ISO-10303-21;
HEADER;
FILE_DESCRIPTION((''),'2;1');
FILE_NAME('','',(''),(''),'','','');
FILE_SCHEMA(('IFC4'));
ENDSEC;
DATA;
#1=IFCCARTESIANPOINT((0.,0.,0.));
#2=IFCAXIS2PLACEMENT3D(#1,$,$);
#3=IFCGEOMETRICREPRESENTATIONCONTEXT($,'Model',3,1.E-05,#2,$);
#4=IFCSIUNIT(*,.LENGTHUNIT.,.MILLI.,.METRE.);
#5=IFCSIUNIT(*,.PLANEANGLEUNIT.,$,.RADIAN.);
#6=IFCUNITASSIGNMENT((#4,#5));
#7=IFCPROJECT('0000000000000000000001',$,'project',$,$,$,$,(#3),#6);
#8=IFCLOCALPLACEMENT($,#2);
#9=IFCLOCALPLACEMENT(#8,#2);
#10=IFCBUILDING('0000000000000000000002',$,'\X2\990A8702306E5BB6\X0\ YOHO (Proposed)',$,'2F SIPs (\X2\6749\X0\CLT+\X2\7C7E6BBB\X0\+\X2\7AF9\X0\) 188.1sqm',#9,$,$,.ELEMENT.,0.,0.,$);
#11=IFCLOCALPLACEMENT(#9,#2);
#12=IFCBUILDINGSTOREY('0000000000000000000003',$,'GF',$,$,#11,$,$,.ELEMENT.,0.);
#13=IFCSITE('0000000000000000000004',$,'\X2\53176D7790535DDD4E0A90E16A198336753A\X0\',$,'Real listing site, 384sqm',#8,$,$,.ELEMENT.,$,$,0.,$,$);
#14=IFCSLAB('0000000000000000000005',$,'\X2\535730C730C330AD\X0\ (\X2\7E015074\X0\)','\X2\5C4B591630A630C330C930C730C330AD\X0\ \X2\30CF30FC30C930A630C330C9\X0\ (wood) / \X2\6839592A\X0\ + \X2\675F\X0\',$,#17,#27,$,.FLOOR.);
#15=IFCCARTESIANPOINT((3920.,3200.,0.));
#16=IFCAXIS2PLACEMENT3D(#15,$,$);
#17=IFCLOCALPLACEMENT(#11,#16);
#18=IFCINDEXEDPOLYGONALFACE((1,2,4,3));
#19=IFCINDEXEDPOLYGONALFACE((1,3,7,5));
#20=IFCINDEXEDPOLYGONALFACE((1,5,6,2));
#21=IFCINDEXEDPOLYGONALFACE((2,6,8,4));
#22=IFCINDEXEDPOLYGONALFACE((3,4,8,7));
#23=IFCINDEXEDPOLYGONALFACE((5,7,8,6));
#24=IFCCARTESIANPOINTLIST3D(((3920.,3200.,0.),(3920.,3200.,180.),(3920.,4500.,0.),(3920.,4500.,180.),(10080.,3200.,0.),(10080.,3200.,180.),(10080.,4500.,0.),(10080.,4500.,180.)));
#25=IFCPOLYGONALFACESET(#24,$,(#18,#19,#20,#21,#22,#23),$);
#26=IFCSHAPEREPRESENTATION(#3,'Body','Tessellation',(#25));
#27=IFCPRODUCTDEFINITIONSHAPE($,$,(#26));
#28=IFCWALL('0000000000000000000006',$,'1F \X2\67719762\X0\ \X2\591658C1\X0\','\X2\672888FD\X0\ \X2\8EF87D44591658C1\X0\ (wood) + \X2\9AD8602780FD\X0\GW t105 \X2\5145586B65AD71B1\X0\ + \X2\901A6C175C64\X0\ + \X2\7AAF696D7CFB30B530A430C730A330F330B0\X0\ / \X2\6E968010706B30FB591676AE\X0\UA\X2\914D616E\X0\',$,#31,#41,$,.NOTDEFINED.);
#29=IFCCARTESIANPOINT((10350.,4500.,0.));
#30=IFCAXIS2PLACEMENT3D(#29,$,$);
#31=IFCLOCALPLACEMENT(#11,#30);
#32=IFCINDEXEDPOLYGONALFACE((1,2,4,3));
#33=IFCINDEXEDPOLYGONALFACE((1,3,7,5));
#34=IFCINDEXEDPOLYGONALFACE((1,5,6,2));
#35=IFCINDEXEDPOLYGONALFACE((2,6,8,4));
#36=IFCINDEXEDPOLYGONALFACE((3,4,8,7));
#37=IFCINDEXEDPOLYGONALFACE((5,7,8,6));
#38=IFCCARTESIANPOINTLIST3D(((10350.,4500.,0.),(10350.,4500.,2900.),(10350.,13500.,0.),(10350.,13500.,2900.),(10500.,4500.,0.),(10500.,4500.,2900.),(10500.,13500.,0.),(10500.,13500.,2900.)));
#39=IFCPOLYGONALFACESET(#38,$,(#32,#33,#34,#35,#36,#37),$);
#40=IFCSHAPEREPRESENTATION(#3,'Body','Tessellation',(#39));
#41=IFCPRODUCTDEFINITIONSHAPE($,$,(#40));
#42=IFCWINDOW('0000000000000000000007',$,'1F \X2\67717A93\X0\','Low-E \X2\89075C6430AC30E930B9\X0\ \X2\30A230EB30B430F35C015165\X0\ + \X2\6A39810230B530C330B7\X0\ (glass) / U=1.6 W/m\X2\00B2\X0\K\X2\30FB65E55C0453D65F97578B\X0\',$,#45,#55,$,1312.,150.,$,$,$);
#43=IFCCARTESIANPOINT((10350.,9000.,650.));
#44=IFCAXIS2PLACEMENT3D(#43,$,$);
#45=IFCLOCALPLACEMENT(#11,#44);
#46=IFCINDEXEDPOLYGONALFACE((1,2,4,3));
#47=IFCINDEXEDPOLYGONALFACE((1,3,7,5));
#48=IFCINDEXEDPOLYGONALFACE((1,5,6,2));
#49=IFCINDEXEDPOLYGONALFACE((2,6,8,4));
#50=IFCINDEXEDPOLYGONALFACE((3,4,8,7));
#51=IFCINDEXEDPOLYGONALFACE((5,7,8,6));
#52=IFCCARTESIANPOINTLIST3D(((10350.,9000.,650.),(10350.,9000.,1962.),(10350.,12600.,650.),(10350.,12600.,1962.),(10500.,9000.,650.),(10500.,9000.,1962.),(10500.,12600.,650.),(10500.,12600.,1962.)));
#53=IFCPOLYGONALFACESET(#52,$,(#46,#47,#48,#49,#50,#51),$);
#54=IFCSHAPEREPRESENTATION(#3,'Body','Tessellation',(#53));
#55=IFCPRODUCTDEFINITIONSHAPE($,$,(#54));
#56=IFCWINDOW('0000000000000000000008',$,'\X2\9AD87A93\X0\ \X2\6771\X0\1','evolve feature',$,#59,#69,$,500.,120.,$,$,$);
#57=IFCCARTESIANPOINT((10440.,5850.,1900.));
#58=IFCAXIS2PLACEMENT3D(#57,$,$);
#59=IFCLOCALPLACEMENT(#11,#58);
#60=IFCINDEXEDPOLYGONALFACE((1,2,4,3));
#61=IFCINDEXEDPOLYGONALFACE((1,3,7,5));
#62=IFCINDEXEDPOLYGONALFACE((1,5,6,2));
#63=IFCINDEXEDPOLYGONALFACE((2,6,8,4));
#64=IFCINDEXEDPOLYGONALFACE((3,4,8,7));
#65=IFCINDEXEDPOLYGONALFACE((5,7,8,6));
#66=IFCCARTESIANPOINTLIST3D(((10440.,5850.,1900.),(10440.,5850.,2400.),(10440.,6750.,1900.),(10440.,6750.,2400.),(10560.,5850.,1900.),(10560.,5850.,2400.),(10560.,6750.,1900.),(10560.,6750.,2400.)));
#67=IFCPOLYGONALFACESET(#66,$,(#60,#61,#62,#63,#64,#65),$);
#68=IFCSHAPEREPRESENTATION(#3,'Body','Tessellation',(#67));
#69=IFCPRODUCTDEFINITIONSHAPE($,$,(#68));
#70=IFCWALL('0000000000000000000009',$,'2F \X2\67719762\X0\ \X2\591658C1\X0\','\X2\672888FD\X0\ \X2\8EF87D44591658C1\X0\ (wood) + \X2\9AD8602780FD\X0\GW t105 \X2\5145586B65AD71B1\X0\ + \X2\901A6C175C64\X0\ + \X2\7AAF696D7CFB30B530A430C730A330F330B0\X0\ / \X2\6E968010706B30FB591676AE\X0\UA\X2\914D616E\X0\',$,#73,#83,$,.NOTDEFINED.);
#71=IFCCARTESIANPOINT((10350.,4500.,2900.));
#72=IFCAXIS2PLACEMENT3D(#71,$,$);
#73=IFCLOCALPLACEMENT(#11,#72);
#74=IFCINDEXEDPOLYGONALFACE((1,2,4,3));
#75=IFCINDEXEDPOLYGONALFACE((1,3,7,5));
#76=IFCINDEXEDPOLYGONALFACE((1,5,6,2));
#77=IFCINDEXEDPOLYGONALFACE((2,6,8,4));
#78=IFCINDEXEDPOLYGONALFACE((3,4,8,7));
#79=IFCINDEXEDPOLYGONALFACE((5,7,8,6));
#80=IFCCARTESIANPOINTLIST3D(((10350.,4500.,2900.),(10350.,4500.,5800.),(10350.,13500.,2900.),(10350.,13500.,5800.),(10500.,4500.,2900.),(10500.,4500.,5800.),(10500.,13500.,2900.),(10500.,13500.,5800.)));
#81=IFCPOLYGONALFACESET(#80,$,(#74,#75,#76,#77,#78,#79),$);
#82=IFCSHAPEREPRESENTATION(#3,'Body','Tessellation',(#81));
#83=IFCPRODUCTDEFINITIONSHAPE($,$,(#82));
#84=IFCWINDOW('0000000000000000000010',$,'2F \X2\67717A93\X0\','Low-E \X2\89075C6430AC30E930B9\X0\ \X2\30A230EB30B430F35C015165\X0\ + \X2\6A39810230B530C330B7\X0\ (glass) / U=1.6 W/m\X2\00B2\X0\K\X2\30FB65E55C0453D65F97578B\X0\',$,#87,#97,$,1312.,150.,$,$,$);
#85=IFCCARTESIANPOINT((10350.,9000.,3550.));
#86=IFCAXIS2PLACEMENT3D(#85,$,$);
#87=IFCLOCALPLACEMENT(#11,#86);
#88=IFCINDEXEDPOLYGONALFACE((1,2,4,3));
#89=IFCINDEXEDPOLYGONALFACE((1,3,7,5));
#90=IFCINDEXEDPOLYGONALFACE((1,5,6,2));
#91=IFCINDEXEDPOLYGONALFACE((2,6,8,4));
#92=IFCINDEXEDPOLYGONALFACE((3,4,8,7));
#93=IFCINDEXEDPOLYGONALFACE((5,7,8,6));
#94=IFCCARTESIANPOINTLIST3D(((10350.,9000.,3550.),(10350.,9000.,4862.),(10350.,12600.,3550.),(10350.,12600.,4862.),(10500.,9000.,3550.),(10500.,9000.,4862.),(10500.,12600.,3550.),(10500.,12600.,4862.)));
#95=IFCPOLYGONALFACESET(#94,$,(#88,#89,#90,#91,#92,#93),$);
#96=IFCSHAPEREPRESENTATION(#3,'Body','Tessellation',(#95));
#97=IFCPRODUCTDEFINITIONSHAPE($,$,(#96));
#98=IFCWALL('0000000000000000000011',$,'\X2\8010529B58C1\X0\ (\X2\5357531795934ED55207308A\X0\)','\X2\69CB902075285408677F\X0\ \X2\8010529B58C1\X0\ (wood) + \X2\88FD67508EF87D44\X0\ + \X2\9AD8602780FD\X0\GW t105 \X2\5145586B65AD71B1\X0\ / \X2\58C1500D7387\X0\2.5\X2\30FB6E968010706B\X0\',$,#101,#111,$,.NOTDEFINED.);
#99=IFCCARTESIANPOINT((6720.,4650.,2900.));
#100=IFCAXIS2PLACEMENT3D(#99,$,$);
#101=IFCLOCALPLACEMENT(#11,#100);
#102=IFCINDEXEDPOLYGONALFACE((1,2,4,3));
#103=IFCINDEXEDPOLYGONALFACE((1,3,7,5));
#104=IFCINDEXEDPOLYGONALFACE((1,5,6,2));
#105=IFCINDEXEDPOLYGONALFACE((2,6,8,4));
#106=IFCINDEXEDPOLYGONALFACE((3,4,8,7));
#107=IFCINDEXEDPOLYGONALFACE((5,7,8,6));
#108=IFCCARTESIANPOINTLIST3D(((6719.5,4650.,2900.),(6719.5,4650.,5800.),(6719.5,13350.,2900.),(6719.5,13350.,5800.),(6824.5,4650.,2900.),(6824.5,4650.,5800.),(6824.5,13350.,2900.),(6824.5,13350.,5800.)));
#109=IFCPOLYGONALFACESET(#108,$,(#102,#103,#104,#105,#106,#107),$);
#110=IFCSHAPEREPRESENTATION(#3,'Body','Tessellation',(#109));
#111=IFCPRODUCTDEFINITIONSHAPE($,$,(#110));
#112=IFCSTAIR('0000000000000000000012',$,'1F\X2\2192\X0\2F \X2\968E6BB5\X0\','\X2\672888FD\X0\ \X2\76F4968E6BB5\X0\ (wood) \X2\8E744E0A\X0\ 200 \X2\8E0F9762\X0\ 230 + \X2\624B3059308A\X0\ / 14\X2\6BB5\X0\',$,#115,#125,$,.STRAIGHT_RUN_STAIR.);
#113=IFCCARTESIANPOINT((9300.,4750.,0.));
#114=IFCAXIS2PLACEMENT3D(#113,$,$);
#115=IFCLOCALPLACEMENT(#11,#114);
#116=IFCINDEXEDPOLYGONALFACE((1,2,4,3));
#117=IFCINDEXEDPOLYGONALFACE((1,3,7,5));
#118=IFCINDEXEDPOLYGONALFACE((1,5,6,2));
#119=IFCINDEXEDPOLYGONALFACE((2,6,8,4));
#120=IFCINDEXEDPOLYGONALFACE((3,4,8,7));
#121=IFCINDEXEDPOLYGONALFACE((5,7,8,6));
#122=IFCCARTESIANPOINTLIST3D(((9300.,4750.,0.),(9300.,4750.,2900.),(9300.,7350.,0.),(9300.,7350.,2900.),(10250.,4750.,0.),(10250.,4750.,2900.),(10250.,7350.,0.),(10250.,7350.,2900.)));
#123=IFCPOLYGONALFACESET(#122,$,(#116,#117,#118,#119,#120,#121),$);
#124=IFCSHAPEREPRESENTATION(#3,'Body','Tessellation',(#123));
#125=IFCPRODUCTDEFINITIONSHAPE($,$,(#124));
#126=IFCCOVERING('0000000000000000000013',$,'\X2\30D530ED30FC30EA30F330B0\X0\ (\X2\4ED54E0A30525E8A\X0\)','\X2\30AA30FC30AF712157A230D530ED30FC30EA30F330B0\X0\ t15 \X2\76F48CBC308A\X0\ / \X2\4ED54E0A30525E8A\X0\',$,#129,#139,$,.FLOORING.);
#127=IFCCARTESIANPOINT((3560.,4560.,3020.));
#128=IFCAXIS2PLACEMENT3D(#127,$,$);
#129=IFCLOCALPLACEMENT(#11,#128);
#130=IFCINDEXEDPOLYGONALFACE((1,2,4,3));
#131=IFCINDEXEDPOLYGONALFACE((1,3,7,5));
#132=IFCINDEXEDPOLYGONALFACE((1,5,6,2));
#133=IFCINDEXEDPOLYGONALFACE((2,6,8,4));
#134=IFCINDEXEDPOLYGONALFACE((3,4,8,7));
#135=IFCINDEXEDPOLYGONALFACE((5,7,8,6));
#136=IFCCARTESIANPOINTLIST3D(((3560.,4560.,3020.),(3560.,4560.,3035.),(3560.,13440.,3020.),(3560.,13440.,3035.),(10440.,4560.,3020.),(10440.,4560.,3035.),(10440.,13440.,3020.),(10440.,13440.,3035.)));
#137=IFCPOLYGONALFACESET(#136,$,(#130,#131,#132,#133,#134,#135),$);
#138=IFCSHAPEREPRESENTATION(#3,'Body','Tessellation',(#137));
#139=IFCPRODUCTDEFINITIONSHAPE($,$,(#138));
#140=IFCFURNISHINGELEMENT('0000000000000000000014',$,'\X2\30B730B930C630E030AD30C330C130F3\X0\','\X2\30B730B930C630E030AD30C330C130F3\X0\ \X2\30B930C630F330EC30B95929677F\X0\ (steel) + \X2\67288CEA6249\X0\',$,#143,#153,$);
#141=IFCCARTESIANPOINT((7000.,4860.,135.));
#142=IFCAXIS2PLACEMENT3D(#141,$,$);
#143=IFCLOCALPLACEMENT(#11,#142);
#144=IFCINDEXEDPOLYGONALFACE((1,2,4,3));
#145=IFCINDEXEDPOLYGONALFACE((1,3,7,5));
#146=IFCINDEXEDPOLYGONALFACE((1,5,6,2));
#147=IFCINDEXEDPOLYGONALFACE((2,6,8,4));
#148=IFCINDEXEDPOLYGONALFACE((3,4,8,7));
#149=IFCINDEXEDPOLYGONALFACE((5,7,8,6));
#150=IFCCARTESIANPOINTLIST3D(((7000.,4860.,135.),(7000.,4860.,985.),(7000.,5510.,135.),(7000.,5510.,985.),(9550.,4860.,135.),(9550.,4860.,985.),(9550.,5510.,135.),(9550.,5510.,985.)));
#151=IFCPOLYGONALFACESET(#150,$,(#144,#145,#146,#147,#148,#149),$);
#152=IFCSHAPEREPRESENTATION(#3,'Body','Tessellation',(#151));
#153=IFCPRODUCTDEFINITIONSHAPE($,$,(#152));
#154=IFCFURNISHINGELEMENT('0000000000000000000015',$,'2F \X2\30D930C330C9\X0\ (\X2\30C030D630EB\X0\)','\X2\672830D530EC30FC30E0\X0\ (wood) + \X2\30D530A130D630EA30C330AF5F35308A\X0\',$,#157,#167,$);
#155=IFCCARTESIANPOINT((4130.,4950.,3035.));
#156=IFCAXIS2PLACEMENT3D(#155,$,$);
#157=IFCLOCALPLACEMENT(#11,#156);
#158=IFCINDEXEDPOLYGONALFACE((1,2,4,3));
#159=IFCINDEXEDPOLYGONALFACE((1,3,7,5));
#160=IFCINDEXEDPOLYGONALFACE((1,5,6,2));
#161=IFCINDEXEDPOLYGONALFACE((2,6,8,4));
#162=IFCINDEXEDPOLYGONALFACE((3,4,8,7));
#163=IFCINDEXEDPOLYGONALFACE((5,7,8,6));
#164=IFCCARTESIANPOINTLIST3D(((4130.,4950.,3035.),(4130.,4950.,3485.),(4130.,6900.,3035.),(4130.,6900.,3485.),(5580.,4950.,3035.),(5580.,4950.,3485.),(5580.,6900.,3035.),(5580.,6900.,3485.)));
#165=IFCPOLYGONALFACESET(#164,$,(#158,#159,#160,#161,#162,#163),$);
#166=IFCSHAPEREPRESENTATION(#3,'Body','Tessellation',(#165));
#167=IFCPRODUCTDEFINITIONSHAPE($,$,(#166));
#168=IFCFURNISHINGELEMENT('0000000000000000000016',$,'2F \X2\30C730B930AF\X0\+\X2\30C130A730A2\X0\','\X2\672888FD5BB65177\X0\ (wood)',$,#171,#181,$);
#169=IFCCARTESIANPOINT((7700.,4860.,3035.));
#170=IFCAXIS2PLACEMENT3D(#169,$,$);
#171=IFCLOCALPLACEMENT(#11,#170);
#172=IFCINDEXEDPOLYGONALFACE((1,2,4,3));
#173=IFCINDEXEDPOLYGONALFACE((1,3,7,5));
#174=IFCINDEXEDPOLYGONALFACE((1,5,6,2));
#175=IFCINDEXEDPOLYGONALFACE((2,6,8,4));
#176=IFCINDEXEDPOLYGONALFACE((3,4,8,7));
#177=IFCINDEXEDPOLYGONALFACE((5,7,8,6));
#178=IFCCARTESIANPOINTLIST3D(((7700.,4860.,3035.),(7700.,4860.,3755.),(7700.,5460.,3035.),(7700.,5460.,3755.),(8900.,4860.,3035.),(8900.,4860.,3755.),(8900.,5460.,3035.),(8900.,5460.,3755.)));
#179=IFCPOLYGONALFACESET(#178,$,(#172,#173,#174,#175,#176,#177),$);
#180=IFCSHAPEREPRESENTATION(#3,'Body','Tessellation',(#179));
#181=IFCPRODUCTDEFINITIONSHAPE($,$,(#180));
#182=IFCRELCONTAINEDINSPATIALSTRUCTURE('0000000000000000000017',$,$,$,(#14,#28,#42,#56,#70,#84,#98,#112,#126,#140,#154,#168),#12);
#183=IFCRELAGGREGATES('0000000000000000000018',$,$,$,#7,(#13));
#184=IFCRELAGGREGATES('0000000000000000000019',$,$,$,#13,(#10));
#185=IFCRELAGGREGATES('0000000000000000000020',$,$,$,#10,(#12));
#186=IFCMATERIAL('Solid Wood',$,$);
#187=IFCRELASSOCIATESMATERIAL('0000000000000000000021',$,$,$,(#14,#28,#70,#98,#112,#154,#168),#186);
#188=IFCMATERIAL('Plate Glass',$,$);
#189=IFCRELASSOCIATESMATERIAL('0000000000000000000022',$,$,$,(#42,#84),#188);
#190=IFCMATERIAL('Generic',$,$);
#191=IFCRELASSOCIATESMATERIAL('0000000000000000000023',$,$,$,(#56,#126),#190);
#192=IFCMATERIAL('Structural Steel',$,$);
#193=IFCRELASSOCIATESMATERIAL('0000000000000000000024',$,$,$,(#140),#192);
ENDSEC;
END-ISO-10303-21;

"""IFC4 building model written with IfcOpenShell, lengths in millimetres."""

from ifc_helpers import new_model, si_unit, frame, frame_2d, origin, place, context, project, spatial, rectangle, extrude, material, element, fill, save


model = new_model("IFC4")

# Units and contexts
model_context = context("Model", 3, precision=1e-05, world=origin())
ifc_project = project(units=[si_unit("LENGTHUNIT", "METRE", prefix="MILLI"), si_unit("PLANEANGLEUNIT", "RADIAN")], contexts=[model_context])

# Site, building, storey
site_placement = place(None, origin())
site = spatial("IfcSite", under=ifc_project, at=site_placement, Name="北海道川上郡標茶町", ObjectType="Real listing site, 384sqm", CompositionType="ELEMENT", RefElevation=0.0)
building_placement = place(site_placement, origin())
building = spatial("IfcBuilding", under=site, at=building_placement, Name="養蜂の家 YOHO (Proposed)", ObjectType="2F SIPs (杉CLT+籾殻+竹) 188.1sqm", CompositionType="ELEMENT", ElevationOfRefHeight=0.0, ElevationOfTerrain=0.0)
storey_placement = place(building_placement, origin())
storey = spatial("IfcBuildingStorey", under=building, at=storey_placement, Name="GF", CompositionType="ELEMENT", Elevation=0.0)

# Slab
ifc_material_1 = material(Name="Solid Wood")
slab_placement = place(storey_placement, frame((3920.0, 3200.0, 0.0)))
element("IfcSlab", 1, at=slab_placement, inside=storey, material=ifc_material_1, Name="南デッキ (縁側)", Description="屋外ウッドデッキ ハードウッド (wood) / 根太 + 束", PredefinedType="FLOOR", context=model_context, shape_type="SweptSolid", body=[
    extrude(rectangle(XDim=6160.0, YDim=1300.0, at=frame_2d((3080.0, 650.0))), frame((3920.0, 3200.0, 0.0)), (0.0, 0.0, 1.0), 180.0),
])

# Wall, openings, windows
wall_1_placement = place(storey_placement, frame((10350.0, 4500.0, 0.0)))
wall_1 = element("IfcWall", 2, at=wall_1_placement, inside=storey, material=ifc_material_1, Name="1F 東面 外壁", Description="木製 軸組外壁 (wood) + 高性能GW t105 充填断熱 + 通気層 + 窯業系サイディング / 準耐火・外皮UA配慮", PredefinedType="NOTDEFINED", context=model_context, shape_type="SweptSolid", body=[
    extrude(rectangle(XDim=150.0, YDim=9000.0, at=frame_2d((75.0, 4500.0))), frame((10350.0, 4500.0, 0.0)), (0.0, 0.0, 1.0), 2900.0),
])
opening_1_placement = place(storey_placement, frame((10350.0, 9000.0, 650.0)))
opening_1 = element("IfcOpeningElement", 3, at=opening_1_placement, cuts=wall_1, PredefinedType="NOTDEFINED", context=model_context, shape_type="SweptSolid", body=[
    extrude(rectangle(XDim=150.0, YDim=3600.0, at=frame_2d((75.0, 1800.0))), frame((10350.0, 9000.0, 650.0)), (0.0, 0.0, 1.0), 1312.0),
])
opening_2_placement = place(storey_placement, frame((10440.0, 5850.0, 1900.0)))
opening_2 = element("IfcOpeningElement", 4, at=opening_2_placement, cuts=wall_1, PredefinedType="NOTDEFINED", context=model_context, shape_type="SweptSolid", body=[
    extrude(rectangle(XDim=120.0, YDim=900.0, at=frame_2d((60.0, 450.0))), frame((10440.0, 5850.0, 1900.0)), (0.0, 0.0, 1.0), 500.0),
])
ifc_material_2 = material(Name="Plate Glass")
window_1_placement = place(storey_placement, frame((10350.0, 9000.0, 650.0)))
window_1 = element("IfcWindow", 5, at=window_1_placement, inside=storey, material=ifc_material_2, Name="1F 東窓", Description="Low-E 複層ガラス アルゴン封入 + 樹脂サッシ (glass) / U=1.6 W/m²K・日射取得型", OverallHeight=1312.0, OverallWidth=150.0, context=model_context, shape_type="SweptSolid", body=[
    extrude(rectangle(XDim=150.0, YDim=3600.0, at=frame_2d((75.0, 1800.0))), frame((10350.0, 9000.0, 650.0)), (0.0, 0.0, 1.0), 1312.0),
])
fill(opening_1, window_1)
ifc_material_3 = material(Name="Generic")
window_2_placement = place(storey_placement, frame((10440.0, 5850.0, 1900.0)))
window_2 = element("IfcWindow", 6, at=window_2_placement, inside=storey, material=ifc_material_3, Name="高窓 東1", Description="evolve feature", OverallHeight=500.0, OverallWidth=120.0, context=model_context, shape_type="SweptSolid", body=[
    extrude(rectangle(XDim=120.0, YDim=900.0, at=frame_2d((60.0, 450.0))), frame((10440.0, 5850.0, 1900.0)), (0.0, 0.0, 1.0), 500.0),
])
fill(opening_2, window_2)

# Wall, opening, window
wall_2_placement = place(storey_placement, frame((10350.0, 4500.0, 2900.0)))
wall_2 = element("IfcWall", 7, at=wall_2_placement, inside=storey, material=ifc_material_1, Name="2F 東面 外壁", Description="木製 軸組外壁 (wood) + 高性能GW t105 充填断熱 + 通気層 + 窯業系サイディング / 準耐火・外皮UA配慮", PredefinedType="NOTDEFINED", context=model_context, shape_type="SweptSolid", body=[
    extrude(rectangle(XDim=150.0, YDim=9000.0, at=frame_2d((75.0, 4500.0))), frame((10350.0, 4500.0, 2900.0)), (0.0, 0.0, 1.0), 2900.0),
])
opening_3_placement = place(storey_placement, frame((10350.0, 9000.0, 3550.0)))
opening_3 = element("IfcOpeningElement", 8, at=opening_3_placement, cuts=wall_2, PredefinedType="NOTDEFINED", context=model_context, shape_type="SweptSolid", body=[
    extrude(rectangle(XDim=150.0, YDim=3600.0, at=frame_2d((75.0, 1800.0))), frame((10350.0, 9000.0, 3550.0)), (0.0, 0.0, 1.0), 1312.0),
])
window_3_placement = place(storey_placement, frame((10350.0, 9000.0, 3550.0)))
window_3 = element("IfcWindow", 9, at=window_3_placement, inside=storey, material=ifc_material_2, Name="2F 東窓", Description="Low-E 複層ガラス アルゴン封入 + 樹脂サッシ (glass) / U=1.6 W/m²K・日射取得型", OverallHeight=1312.0, OverallWidth=150.0, context=model_context, shape_type="SweptSolid", body=[
    extrude(rectangle(XDim=150.0, YDim=3600.0, at=frame_2d((75.0, 1800.0))), frame((10350.0, 9000.0, 3550.0)), (0.0, 0.0, 1.0), 1312.0),
])
fill(opening_3, window_3)

# Wall
wall_3_placement = place(storey_placement, frame((6720.0, 4650.0, 2900.0)))
element("IfcWall", 10, at=wall_3_placement, inside=storey, material=ifc_material_1, Name="耐力壁 (南北間仕切り)", Description="構造用合板 耐力壁 (wood) + 製材軸組 + 高性能GW t105 充填断熱 / 壁倍率2.5・準耐火", PredefinedType="NOTDEFINED", context=model_context, shape_type="SweptSolid", body=[
    extrude(rectangle(XDim=105.0, YDim=8700.0, at=frame_2d((52.0, 4350.0))), frame((6720.0, 4650.0, 2900.0)), (0.0, 0.0, 1.0), 2900.0),
])

# Stair
stair_placement = place(storey_placement, frame((9300.0, 4750.0, 0.0)))
element("IfcStair", 11, at=stair_placement, inside=storey, material=ifc_material_1, Name="1F→2F 階段", Description="木製 直階段 (wood) 蹴上 200 踏面 230 + 手すり / 14段", PredefinedType="STRAIGHT_RUN_STAIR", context=model_context, shape_type="SweptSolid", body=[
    extrude(rectangle(XDim=950.0, YDim=2600.0, at=frame_2d((475.0, 1300.0))), frame((9300.0, 4750.0, 0.0)), (0.0, 0.0, 1.0), 2900.0),
])

# Covering
covering_placement = place(storey_placement, frame((3560.0, 4560.0, 3020.0)))
element("IfcCovering", 12, at=covering_placement, inside=storey, material=ifc_material_3, Name="フローリング (仕上げ床)", Description="オーク無垢フローリング t15 直貼り / 仕上げ床", PredefinedType="FLOORING", context=model_context, shape_type="SweptSolid", body=[
    extrude(rectangle(XDim=6880.0, YDim=8880.0, at=frame_2d((3440.0, 4440.0))), frame((3560.0, 4560.0, 3020.0)), (0.0, 0.0, 1.0), 15.0),
])

# Furnishing elements
ifc_material_4 = material(Name="Structural Steel")
furnishing_1_placement = place(storey_placement, frame((7000.0, 4860.0, 135.0)))
element("IfcFurnishingElement", 13, at=furnishing_1_placement, inside=storey, material=ifc_material_4, Name="システムキッチン", Description="システムキッチン ステンレス天板 (steel) + 木質扉", context=model_context, shape_type="SweptSolid", body=[
    extrude(rectangle(XDim=2550.0, YDim=650.0, at=frame_2d((1275.0, 325.0))), frame((7000.0, 4860.0, 135.0)), (0.0, 0.0, 1.0), 850.0),
])
furnishing_2_placement = place(storey_placement, frame((4130.0, 4950.0, 3035.0)))
element("IfcFurnishingElement", 14, at=furnishing_2_placement, inside=storey, material=ifc_material_1, Name="2F ベッド (ダブル)", Description="木フレーム (wood) + ファブリック張り", context=model_context, shape_type="SweptSolid", body=[
    extrude(rectangle(XDim=1450.0, YDim=1950.0, at=frame_2d((725.0, 975.0))), frame((4130.0, 4950.0, 3035.0)), (0.0, 0.0, 1.0), 450.0),
])
furnishing_3_placement = place(storey_placement, frame((7700.0, 4860.0, 3035.0)))
element("IfcFurnishingElement", 15, at=furnishing_3_placement, inside=storey, material=ifc_material_1, Name="2F デスク+チェア", Description="木製家具 (wood)", context=model_context, shape_type="SweptSolid", body=[
    extrude(rectangle(XDim=1200.0, YDim=600.0, at=frame_2d((600.0, 300.0))), frame((7700.0, 4860.0, 3035.0)), (0.0, 0.0, 1.0), 720.0),
])

save(model, "model.ifc")
